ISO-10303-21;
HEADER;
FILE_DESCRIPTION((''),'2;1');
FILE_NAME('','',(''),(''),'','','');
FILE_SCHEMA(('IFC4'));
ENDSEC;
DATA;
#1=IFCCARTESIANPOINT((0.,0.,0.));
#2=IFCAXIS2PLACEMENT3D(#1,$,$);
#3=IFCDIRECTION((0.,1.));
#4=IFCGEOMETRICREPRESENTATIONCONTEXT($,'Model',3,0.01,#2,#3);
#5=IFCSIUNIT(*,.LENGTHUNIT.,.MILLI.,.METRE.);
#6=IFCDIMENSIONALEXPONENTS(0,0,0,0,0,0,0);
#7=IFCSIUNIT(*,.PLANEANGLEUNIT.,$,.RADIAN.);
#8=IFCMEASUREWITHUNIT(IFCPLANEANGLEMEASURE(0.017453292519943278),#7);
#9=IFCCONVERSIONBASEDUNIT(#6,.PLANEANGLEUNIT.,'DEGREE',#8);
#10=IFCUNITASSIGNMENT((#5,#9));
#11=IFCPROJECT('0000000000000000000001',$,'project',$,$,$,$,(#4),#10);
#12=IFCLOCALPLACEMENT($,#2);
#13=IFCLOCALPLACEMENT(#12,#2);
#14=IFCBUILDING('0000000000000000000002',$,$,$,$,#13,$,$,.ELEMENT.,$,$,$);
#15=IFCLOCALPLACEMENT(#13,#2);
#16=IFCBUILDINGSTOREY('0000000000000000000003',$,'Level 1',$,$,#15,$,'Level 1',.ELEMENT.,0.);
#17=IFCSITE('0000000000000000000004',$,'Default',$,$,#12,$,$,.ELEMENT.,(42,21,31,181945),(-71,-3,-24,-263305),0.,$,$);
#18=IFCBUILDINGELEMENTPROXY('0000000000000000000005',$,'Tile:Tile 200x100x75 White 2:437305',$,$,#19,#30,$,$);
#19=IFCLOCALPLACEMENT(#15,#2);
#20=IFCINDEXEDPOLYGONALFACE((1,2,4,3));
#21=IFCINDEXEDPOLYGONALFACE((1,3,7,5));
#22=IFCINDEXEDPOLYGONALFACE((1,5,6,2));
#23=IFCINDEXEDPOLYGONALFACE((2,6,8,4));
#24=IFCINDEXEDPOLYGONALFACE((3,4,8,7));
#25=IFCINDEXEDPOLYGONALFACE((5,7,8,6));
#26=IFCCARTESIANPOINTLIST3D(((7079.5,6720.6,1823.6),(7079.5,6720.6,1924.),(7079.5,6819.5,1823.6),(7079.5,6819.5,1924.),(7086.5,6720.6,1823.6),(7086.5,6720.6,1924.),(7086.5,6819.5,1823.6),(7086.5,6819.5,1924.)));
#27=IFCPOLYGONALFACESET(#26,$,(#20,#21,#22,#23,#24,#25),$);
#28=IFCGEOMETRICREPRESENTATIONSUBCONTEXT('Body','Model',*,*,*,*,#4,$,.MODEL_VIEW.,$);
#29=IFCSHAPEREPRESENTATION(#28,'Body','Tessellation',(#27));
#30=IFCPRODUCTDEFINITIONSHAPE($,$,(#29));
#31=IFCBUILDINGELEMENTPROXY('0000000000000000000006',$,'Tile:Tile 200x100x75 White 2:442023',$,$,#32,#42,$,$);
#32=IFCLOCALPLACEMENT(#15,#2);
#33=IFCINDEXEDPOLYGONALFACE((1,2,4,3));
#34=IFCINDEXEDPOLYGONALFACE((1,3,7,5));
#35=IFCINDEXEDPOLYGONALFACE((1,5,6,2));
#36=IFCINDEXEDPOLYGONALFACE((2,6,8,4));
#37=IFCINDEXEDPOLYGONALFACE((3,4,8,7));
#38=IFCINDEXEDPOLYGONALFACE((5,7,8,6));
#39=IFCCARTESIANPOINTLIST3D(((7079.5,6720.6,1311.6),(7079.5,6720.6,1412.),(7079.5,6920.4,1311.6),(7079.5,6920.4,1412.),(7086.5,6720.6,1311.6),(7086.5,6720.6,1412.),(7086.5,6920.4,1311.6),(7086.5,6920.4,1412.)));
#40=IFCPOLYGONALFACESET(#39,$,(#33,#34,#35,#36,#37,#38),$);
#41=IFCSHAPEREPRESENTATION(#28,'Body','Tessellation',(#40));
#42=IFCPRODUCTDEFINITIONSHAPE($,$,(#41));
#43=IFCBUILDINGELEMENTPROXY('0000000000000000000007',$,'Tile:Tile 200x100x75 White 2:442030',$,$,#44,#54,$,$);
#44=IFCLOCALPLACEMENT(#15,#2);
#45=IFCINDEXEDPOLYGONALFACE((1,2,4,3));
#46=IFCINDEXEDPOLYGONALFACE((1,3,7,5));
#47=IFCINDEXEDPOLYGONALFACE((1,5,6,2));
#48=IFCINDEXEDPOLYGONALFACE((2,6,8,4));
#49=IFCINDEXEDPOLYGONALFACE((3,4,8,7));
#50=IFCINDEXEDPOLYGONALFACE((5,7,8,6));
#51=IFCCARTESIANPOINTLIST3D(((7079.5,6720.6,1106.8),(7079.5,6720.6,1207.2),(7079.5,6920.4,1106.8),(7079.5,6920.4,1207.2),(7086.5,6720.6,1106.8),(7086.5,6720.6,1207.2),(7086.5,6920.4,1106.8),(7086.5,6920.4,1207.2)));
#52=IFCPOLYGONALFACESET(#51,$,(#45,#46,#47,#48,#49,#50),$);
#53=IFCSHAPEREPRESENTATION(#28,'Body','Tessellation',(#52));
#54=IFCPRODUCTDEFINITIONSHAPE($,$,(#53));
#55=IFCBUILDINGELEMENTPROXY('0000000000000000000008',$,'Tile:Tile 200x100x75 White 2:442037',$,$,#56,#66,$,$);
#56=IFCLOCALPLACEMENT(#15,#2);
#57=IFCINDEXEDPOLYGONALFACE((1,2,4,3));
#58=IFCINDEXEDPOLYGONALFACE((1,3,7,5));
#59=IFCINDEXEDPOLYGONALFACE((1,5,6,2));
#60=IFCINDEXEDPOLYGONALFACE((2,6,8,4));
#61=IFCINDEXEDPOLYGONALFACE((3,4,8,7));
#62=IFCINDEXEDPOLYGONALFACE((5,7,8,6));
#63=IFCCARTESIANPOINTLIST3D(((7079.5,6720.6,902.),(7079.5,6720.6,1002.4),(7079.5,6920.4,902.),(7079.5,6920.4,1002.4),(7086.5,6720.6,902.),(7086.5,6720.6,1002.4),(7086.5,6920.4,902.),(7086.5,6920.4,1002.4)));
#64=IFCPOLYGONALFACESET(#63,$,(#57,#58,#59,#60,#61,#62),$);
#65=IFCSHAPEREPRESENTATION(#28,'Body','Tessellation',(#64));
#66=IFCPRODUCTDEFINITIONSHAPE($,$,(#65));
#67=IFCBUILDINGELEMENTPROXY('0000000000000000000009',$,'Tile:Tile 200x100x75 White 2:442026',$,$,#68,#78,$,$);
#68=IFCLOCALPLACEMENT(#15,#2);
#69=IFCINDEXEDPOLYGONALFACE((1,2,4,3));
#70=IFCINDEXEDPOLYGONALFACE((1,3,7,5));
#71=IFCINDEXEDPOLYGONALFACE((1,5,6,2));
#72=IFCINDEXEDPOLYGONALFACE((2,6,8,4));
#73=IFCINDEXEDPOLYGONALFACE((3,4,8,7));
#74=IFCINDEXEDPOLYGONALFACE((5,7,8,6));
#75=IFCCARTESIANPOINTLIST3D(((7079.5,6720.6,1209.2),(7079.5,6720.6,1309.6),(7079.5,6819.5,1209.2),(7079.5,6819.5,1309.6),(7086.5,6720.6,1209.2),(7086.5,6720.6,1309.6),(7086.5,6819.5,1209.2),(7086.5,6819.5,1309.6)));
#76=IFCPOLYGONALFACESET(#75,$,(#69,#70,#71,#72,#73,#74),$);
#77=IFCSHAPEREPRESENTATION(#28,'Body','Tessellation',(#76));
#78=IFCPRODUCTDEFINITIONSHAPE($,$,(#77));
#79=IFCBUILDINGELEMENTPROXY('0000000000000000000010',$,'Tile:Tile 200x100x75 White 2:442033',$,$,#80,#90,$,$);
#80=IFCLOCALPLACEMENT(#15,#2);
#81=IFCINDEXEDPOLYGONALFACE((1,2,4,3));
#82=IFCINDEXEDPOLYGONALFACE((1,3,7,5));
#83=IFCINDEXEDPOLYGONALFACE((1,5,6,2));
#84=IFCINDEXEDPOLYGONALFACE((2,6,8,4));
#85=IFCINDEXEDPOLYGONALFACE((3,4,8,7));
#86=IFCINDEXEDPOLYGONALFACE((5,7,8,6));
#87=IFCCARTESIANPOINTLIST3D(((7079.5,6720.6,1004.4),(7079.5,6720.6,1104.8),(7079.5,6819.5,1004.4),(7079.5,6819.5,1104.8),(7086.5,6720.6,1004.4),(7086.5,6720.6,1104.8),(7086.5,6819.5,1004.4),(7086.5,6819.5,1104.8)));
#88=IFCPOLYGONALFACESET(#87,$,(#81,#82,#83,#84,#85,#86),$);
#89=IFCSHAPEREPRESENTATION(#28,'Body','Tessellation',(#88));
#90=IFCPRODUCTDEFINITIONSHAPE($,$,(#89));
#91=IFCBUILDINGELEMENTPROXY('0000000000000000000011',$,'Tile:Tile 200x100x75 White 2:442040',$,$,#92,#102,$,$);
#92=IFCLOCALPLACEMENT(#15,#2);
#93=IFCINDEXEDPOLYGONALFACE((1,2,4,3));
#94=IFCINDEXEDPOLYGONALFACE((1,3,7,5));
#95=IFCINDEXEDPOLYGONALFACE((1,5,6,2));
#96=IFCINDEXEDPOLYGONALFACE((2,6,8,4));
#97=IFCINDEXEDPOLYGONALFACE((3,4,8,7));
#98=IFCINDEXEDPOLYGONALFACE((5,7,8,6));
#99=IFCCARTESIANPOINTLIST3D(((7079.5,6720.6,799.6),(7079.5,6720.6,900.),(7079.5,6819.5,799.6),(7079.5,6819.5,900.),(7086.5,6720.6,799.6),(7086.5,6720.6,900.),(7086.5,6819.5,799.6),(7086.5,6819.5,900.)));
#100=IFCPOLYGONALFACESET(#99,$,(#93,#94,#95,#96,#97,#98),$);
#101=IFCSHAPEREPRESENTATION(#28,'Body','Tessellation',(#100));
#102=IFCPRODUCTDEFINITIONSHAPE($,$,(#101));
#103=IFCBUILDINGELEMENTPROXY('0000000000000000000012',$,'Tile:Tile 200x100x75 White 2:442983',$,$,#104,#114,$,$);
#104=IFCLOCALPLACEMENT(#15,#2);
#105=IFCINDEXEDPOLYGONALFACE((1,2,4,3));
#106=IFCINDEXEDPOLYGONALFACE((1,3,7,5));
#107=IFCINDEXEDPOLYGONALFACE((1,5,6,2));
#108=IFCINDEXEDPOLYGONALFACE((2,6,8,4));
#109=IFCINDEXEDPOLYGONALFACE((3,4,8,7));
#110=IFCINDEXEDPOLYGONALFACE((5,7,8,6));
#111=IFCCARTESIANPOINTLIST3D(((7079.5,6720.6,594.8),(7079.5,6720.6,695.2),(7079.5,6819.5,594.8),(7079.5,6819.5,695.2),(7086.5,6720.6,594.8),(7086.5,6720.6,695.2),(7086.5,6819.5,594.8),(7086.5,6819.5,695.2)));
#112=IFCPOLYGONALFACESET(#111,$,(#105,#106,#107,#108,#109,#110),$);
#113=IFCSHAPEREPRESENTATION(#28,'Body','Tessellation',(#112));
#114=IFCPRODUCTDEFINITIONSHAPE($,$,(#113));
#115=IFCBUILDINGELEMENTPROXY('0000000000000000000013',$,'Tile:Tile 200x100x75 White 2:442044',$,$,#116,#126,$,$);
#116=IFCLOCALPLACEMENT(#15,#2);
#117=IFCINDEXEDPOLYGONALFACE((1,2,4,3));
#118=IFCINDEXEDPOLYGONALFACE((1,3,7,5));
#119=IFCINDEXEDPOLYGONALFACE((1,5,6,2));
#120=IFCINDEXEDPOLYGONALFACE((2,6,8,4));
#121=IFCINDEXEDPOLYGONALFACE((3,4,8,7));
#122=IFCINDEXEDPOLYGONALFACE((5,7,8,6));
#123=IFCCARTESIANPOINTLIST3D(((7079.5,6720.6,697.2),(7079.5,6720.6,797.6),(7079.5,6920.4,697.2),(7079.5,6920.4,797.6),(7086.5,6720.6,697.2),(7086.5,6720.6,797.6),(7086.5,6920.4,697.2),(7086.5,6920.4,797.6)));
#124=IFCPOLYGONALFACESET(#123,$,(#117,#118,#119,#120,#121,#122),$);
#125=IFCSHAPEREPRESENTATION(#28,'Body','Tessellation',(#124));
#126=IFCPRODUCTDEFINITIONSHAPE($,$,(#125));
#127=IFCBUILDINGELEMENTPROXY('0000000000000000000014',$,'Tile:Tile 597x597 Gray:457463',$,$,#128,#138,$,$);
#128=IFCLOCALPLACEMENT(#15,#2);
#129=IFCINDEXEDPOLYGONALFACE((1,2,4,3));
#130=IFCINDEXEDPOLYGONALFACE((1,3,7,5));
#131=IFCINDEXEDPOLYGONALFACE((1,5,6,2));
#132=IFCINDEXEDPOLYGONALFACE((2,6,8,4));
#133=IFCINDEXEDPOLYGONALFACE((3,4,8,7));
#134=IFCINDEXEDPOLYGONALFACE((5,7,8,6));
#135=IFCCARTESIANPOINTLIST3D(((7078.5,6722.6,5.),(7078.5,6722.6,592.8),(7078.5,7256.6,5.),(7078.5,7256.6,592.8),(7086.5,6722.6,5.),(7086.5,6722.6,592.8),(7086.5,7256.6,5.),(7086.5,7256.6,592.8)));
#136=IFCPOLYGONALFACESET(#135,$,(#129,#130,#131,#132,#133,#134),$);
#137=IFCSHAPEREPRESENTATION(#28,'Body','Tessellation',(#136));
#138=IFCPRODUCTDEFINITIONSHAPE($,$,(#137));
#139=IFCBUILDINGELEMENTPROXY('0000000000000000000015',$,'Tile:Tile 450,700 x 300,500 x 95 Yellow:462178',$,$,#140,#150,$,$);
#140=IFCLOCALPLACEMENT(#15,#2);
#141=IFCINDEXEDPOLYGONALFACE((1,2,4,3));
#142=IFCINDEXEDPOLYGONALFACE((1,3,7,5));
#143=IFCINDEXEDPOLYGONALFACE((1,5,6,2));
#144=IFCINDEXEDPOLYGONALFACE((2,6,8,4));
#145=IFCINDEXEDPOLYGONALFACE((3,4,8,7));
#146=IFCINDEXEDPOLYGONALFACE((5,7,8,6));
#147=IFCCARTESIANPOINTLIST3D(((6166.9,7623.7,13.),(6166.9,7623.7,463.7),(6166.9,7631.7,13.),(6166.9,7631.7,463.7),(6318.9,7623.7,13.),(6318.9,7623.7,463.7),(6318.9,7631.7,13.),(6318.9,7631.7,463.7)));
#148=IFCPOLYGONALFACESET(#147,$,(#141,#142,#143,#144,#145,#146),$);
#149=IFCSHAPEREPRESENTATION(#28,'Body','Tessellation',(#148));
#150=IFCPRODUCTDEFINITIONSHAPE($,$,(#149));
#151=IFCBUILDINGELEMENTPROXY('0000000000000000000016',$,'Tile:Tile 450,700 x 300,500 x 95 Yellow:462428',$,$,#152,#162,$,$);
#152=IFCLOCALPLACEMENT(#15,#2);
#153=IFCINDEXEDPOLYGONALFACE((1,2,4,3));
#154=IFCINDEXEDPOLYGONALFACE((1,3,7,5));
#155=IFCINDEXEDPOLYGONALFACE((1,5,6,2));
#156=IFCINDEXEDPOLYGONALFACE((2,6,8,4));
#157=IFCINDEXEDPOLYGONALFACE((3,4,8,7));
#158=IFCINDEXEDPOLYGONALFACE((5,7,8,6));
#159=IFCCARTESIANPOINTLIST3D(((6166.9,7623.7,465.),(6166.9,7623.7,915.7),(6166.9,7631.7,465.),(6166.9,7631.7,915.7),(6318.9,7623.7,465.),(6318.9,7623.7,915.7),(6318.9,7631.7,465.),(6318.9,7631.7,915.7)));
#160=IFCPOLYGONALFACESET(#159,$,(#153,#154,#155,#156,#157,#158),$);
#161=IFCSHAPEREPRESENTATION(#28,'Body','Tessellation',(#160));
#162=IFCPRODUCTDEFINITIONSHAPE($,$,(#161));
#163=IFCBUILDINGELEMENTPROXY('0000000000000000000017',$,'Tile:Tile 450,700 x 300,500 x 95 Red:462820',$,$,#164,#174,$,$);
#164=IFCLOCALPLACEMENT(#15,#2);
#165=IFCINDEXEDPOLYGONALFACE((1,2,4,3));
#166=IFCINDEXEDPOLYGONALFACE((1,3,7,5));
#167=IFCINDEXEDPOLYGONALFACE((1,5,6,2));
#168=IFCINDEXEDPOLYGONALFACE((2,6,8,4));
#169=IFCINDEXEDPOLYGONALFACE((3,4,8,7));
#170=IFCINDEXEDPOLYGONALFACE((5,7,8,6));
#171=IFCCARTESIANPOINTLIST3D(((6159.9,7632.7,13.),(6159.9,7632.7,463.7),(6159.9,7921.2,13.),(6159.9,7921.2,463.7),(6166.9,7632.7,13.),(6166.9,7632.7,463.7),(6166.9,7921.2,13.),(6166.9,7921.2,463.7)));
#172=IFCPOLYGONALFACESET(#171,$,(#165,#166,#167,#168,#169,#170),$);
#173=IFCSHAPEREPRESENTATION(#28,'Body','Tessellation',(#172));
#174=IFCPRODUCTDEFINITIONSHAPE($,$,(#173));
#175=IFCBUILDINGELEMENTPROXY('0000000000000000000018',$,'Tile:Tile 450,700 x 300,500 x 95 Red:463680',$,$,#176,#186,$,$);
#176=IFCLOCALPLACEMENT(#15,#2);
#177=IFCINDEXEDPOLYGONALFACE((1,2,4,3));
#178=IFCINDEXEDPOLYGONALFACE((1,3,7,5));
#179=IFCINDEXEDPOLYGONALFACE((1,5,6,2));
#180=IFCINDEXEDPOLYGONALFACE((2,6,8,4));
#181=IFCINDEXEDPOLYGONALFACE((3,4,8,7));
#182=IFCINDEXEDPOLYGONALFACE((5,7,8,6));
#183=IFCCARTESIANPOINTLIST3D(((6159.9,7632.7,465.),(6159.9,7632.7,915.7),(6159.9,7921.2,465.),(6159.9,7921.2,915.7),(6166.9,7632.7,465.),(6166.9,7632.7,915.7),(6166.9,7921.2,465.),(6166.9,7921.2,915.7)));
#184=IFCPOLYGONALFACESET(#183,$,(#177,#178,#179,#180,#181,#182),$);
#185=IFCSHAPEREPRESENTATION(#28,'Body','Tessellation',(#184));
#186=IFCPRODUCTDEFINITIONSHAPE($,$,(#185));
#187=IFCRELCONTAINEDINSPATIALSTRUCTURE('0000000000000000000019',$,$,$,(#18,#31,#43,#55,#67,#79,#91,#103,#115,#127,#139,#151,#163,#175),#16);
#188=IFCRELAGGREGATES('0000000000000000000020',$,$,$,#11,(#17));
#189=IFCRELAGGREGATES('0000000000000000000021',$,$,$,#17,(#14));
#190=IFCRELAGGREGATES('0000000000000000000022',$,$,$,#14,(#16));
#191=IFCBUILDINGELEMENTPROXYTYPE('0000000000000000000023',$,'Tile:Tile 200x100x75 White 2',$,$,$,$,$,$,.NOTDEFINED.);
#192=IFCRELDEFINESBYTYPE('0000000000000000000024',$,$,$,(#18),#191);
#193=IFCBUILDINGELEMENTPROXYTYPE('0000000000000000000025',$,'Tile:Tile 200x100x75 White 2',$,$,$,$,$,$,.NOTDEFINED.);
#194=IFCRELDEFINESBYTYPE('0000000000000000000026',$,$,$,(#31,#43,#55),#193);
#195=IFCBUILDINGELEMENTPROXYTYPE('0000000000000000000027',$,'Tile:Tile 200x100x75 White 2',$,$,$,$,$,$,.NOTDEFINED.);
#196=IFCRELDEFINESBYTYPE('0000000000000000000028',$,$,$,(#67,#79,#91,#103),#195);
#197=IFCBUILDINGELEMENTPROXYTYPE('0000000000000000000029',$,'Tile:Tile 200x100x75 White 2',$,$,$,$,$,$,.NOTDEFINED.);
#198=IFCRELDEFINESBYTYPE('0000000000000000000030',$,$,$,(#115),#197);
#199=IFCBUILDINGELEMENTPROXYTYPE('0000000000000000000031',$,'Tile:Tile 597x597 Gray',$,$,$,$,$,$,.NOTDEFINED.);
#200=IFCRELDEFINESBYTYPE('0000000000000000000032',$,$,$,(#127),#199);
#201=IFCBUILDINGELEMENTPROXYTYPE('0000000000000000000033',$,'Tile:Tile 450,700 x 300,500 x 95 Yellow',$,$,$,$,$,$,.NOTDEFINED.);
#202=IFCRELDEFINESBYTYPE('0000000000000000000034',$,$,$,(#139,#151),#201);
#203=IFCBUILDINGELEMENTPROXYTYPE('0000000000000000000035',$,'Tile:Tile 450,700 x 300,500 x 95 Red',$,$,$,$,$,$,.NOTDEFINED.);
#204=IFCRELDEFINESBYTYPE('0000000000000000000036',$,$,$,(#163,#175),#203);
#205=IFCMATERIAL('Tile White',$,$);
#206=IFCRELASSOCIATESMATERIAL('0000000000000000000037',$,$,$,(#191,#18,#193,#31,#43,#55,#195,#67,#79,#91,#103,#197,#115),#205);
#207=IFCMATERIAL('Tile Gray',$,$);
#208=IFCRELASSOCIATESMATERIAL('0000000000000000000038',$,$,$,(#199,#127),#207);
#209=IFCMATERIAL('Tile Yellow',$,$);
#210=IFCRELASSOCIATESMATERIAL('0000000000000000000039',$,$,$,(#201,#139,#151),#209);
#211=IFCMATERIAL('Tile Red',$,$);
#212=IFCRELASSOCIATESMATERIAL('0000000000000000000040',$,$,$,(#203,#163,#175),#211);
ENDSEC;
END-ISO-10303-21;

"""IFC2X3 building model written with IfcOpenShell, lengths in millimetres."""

from ifc_helpers import new_model, entity, si_unit, converted_unit, direction, frame, frame_2d, origin, origin_2d_with_axis, place, context, subcontext, project, spatial, rectangle, extrude, source, transform, mapped, material, type_object, type_shapes, element, save


model = new_model("IFC2X3")

# Units and contexts
model_context = context("Model", 3, precision=0.01, world=origin(), true_north=direction((0.0, 1.0)))
body_context = subcontext(model_context, "Body", "Model", "MODEL_VIEW")
ifc_project = project(units=[si_unit("LENGTHUNIT", "METRE", prefix="MILLI"), converted_unit("PLANEANGLEUNIT", "DEGREE", entity("IfcPlaneAngleMeasure", 0.017453292519943278), si_unit("PLANEANGLEUNIT", "RADIAN"), dimensions=[0, 0, 0, 0, 0, 0, 0])], contexts=[model_context])

# Site, building, storey
site_placement = place(None, origin())
site = spatial("IfcSite", under=ifc_project, at=site_placement, Name="Default", CompositionType="ELEMENT", RefLatitude=(42, 21, 31, 181945), RefLongitude=(-71, -3, -24, -263305), RefElevation=0.0)
building_placement = place(site_placement, origin())
building = spatial("IfcBuilding", under=site, at=building_placement, CompositionType="ELEMENT")
storey_placement = place(building_placement, origin())
storey = spatial("IfcBuildingStorey", under=building, at=storey_placement, Name="Level 1", LongName="Level 1", CompositionType="ELEMENT", Elevation=0.0)

# Building element proxies
ifc_material_1 = material(Name="Tile White")
building_element_proxy_type_1 = type_object("IfcBuildingElementProxyType", Name="Tile:Tile 200x100x75 White 2", PredefinedType="NOTDEFINED", material=ifc_material_1)
shared_shape_1 = source(origin(), body_context, "Body", "SweptSolid", [
    extrude(rectangle(XDim=98.9, YDim=100.4, at=origin_2d_with_axis()), frame((-50.2, -49.5, 0.0), z_axis=(0.0, 0.0, 1.0), x_axis=(0.0, -1.0, 0.0)), (0.0, 0.0, 1.0), 7.0),
])
type_shapes(building_element_proxy_type_1, [shared_shape_1])
proxy_1_placement = place(storey_placement, frame((7086.5, 6819.5, 1924.0), z_axis=(-1.0, 0.0, 0.0), x_axis=(0.0, 0.0, 1.0)))
element("IfcBuildingElementProxy", 1, at=proxy_1_placement, inside=storey, type_object=building_element_proxy_type_1, material=ifc_material_1, Name="Tile:Tile 200x100x75 White 2:437305", context=body_context, shape_type="MappedRepresentation", body=[
    mapped(shared_shape_1, transform((0.0, 0.0, 0.0), scale=1.0)),
])
building_element_proxy_type_2 = type_object("IfcBuildingElementProxyType", Name="Tile:Tile 200x100x75 White 2", PredefinedType="NOTDEFINED", material=ifc_material_1)
shared_shape_2 = source(origin(), body_context, "Body", "SweptSolid", [
    extrude(rectangle(XDim=100.4, YDim=199.8, at=origin_2d_with_axis()), frame((-50.2, 99.9, 0.0)), (0.0, 0.0, 1.0), 7.0),
])
type_shapes(building_element_proxy_type_2, [shared_shape_2])
for number, where, z_axis, x_axis, name in (
    (2, (7086.5, 6720.6, 1412.0), (-1.0, 0.0, 0.0), (0.0, 0.0, 1.0), "Tile:Tile 200x100x75 White 2:442023"),
    (3, (7086.5, 6720.6, 1207.2), (-1.0, 0.0, 0.0), (0.0, 0.0, 1.0), "Tile:Tile 200x100x75 White 2:442030"),
    (4, (7086.5, 6720.6, 1002.4), (-1.0, 0.0, 0.0), (0.0, 0.0, 1.0), "Tile:Tile 200x100x75 White 2:442037"),
):
    element("IfcBuildingElementProxy", number, at=place(storey_placement, frame(where, z_axis=z_axis, x_axis=x_axis)), inside=storey, type_object=building_element_proxy_type_2, material=ifc_material_1, Name=name, context=body_context, shape_type="MappedRepresentation", body=[
        mapped(shared_shape_2, transform((0.0, 0.0, 0.0), scale=1.0)),
    ])
building_element_proxy_type_3 = type_object("IfcBuildingElementProxyType", Name="Tile:Tile 200x100x75 White 2", PredefinedType="NOTDEFINED", material=ifc_material_1)
shared_shape_3 = source(origin(), body_context, "Body", "SweptSolid", [
    extrude(rectangle(XDim=100.4, YDim=98.9, at=origin_2d_with_axis()), frame((-50.2, 49.5, 0.0)), (0.0, 0.0, 1.0), 7.0),
])
type_shapes(building_element_proxy_type_3, [shared_shape_3])
for number, where, z_axis, x_axis, name in (
    (5, (7086.5, 6720.6, 1309.6), (-1.0, 0.0, 0.0), (0.0, 0.0, 1.0), "Tile:Tile 200x100x75 White 2:442026"),
    (6, (7086.5, 6720.6, 1104.8), (-1.0, 0.0, 0.0), (0.0, 0.0, 1.0), "Tile:Tile 200x100x75 White 2:442033"),
    (7, (7086.5, 6720.6, 900.0), (-1.0, 0.0, 0.0), (0.0, 0.0, 1.0), "Tile:Tile 200x100x75 White 2:442040"),
    (8, (7086.5, 6720.6, 695.2), (-1.0, 0.0, 0.0), (0.0, 0.0, 1.0), "Tile:Tile 200x100x75 White 2:442983"),
):
    element("IfcBuildingElementProxy", number, at=place(storey_placement, frame(where, z_axis=z_axis, x_axis=x_axis)), inside=storey, type_object=building_element_proxy_type_3, material=ifc_material_1, Name=name, context=body_context, shape_type="MappedRepresentation", body=[
        mapped(shared_shape_3, transform((0.0, 0.0, 0.0), scale=1.0)),
    ])
building_element_proxy_type_4 = type_object("IfcBuildingElementProxyType", Name="Tile:Tile 200x100x75 White 2", PredefinedType="NOTDEFINED", material=ifc_material_1)
shared_shape_4 = source(origin(), body_context, "Body", "SweptSolid", [
    extrude(rectangle(XDim=100.4, YDim=199.8, at=origin_2d_with_axis()), frame((-50.2, 99.9, 0.0)), (0.0, 0.0, 1.0), 7.0),
])
type_shapes(building_element_proxy_type_4, [shared_shape_4])
proxy_2_placement = place(storey_placement, frame((7086.5, 6720.6, 797.6), z_axis=(-1.0, 0.0, 0.0), x_axis=(0.0, 0.0, 1.0)))
element("IfcBuildingElementProxy", 9, at=proxy_2_placement, inside=storey, type_object=building_element_proxy_type_4, material=ifc_material_1, Name="Tile:Tile 200x100x75 White 2:442044", context=body_context, shape_type="MappedRepresentation", body=[
    mapped(shared_shape_4, transform((0.0, 0.0, 0.0), scale=1.0)),
])
ifc_material_2 = material(Name="Tile Gray")
building_element_proxy_type_5 = type_object("IfcBuildingElementProxyType", Name="Tile:Tile 597x597 Gray", PredefinedType="NOTDEFINED", material=ifc_material_2)
shared_shape_5 = source(origin(), body_context, "Body", "SweptSolid", [
    extrude(rectangle(XDim=534.0, YDim=587.8, at=frame_2d((0.0, 0.0), x_axis=(1.0, 0.0))), frame((-267.0, -293.9, 0.0), z_axis=(0.0, 0.0, 1.0), x_axis=(-1.0, 0.0, 0.0)), (0.0, 0.0, 1.0), 8.0),
])
type_shapes(building_element_proxy_type_5, [shared_shape_5])
proxy_3_placement = place(storey_placement, frame((7086.5, 6722.6, 592.8), z_axis=(-1.0, 0.0, 0.0), x_axis=(0.0, -1.0, 0.0)))
element("IfcBuildingElementProxy", 10, at=proxy_3_placement, inside=storey, type_object=building_element_proxy_type_5, material=ifc_material_2, Name="Tile:Tile 597x597 Gray:457463", context=body_context, shape_type="MappedRepresentation", body=[
    mapped(shared_shape_5, transform((0.0, 0.0, 0.0), scale=1.0)),
])
ifc_material_3 = material(Name="Tile Yellow")
building_element_proxy_type_6 = type_object("IfcBuildingElementProxyType", Name="Tile:Tile 450,700 x 300,500 x 95 Yellow", PredefinedType="NOTDEFINED", material=ifc_material_3)
shared_shape_6 = source(origin(), body_context, "Body", "SweptSolid", [
    extrude(rectangle(XDim=152.0, YDim=450.7, at=frame_2d((0.0, 0.0), x_axis=(1.0, 0.0))), frame((-76.0, -225.4, 0.0), z_axis=(0.0, 0.0, 1.0), x_axis=(-1.0, 0.0, 0.0)), (0.0, 0.0, 1.0), 8.0),
])
type_shapes(building_element_proxy_type_6, [shared_shape_6])
for number, where, z_axis, x_axis, name in (
    (11, (6166.9, 7631.7, 13.0), (0.0, -1.0, 0.0), (-1.0, 0.0, 0.0), "Tile:Tile 450,700 x 300,500 x 95 Yellow:462178"),
    (12, (6166.9, 7631.7, 465.0), (0.0, -1.0, 0.0), (-1.0, 0.0, 0.0), "Tile:Tile 450,700 x 300,500 x 95 Yellow:462428"),
):
    element("IfcBuildingElementProxy", number, at=place(storey_placement, frame(where, z_axis=z_axis, x_axis=x_axis)), inside=storey, type_object=building_element_proxy_type_6, material=ifc_material_3, Name=name, context=body_context, shape_type="MappedRepresentation", body=[
        mapped(shared_shape_6, transform((0.0, 0.0, 0.0), scale=1.0)),
    ])
ifc_material_4 = material(Name="Tile Red")
building_element_proxy_type_7 = type_object("IfcBuildingElementProxyType", Name="Tile:Tile 450,700 x 300,500 x 95 Red", PredefinedType="NOTDEFINED", material=ifc_material_4)
shared_shape_7 = source(origin(), body_context, "Body", "SweptSolid", [
    extrude(rectangle(XDim=450.7, YDim=288.5, at=origin_2d_with_axis()), frame((-144.2, 225.4, 0.0), z_axis=(0.0, 0.0, 1.0), x_axis=(0.0, 1.0, 0.0)), (0.0, 0.0, 1.0), 7.0),
])
type_shapes(building_element_proxy_type_7, [shared_shape_7])
for number, where, z_axis, x_axis, name in (
    (13, (6166.9, 7632.7, 13.0), (-1.0, 0.0, 0.0), (0.0, -1.0, 0.0), "Tile:Tile 450,700 x 300,500 x 95 Red:462820"),
    (14, (6166.9, 7632.7, 465.0), (-1.0, 0.0, 0.0), (0.0, -1.0, 0.0), "Tile:Tile 450,700 x 300,500 x 95 Red:463680"),
):
    element("IfcBuildingElementProxy", number, at=place(storey_placement, frame(where, z_axis=z_axis, x_axis=x_axis)), inside=storey, type_object=building_element_proxy_type_7, material=ifc_material_4, Name=name, context=body_context, shape_type="MappedRepresentation", body=[
        mapped(shared_shape_7, transform((0.0, 0.0, 0.0), scale=1.0)),
    ])

save(model, "model.ifc")
